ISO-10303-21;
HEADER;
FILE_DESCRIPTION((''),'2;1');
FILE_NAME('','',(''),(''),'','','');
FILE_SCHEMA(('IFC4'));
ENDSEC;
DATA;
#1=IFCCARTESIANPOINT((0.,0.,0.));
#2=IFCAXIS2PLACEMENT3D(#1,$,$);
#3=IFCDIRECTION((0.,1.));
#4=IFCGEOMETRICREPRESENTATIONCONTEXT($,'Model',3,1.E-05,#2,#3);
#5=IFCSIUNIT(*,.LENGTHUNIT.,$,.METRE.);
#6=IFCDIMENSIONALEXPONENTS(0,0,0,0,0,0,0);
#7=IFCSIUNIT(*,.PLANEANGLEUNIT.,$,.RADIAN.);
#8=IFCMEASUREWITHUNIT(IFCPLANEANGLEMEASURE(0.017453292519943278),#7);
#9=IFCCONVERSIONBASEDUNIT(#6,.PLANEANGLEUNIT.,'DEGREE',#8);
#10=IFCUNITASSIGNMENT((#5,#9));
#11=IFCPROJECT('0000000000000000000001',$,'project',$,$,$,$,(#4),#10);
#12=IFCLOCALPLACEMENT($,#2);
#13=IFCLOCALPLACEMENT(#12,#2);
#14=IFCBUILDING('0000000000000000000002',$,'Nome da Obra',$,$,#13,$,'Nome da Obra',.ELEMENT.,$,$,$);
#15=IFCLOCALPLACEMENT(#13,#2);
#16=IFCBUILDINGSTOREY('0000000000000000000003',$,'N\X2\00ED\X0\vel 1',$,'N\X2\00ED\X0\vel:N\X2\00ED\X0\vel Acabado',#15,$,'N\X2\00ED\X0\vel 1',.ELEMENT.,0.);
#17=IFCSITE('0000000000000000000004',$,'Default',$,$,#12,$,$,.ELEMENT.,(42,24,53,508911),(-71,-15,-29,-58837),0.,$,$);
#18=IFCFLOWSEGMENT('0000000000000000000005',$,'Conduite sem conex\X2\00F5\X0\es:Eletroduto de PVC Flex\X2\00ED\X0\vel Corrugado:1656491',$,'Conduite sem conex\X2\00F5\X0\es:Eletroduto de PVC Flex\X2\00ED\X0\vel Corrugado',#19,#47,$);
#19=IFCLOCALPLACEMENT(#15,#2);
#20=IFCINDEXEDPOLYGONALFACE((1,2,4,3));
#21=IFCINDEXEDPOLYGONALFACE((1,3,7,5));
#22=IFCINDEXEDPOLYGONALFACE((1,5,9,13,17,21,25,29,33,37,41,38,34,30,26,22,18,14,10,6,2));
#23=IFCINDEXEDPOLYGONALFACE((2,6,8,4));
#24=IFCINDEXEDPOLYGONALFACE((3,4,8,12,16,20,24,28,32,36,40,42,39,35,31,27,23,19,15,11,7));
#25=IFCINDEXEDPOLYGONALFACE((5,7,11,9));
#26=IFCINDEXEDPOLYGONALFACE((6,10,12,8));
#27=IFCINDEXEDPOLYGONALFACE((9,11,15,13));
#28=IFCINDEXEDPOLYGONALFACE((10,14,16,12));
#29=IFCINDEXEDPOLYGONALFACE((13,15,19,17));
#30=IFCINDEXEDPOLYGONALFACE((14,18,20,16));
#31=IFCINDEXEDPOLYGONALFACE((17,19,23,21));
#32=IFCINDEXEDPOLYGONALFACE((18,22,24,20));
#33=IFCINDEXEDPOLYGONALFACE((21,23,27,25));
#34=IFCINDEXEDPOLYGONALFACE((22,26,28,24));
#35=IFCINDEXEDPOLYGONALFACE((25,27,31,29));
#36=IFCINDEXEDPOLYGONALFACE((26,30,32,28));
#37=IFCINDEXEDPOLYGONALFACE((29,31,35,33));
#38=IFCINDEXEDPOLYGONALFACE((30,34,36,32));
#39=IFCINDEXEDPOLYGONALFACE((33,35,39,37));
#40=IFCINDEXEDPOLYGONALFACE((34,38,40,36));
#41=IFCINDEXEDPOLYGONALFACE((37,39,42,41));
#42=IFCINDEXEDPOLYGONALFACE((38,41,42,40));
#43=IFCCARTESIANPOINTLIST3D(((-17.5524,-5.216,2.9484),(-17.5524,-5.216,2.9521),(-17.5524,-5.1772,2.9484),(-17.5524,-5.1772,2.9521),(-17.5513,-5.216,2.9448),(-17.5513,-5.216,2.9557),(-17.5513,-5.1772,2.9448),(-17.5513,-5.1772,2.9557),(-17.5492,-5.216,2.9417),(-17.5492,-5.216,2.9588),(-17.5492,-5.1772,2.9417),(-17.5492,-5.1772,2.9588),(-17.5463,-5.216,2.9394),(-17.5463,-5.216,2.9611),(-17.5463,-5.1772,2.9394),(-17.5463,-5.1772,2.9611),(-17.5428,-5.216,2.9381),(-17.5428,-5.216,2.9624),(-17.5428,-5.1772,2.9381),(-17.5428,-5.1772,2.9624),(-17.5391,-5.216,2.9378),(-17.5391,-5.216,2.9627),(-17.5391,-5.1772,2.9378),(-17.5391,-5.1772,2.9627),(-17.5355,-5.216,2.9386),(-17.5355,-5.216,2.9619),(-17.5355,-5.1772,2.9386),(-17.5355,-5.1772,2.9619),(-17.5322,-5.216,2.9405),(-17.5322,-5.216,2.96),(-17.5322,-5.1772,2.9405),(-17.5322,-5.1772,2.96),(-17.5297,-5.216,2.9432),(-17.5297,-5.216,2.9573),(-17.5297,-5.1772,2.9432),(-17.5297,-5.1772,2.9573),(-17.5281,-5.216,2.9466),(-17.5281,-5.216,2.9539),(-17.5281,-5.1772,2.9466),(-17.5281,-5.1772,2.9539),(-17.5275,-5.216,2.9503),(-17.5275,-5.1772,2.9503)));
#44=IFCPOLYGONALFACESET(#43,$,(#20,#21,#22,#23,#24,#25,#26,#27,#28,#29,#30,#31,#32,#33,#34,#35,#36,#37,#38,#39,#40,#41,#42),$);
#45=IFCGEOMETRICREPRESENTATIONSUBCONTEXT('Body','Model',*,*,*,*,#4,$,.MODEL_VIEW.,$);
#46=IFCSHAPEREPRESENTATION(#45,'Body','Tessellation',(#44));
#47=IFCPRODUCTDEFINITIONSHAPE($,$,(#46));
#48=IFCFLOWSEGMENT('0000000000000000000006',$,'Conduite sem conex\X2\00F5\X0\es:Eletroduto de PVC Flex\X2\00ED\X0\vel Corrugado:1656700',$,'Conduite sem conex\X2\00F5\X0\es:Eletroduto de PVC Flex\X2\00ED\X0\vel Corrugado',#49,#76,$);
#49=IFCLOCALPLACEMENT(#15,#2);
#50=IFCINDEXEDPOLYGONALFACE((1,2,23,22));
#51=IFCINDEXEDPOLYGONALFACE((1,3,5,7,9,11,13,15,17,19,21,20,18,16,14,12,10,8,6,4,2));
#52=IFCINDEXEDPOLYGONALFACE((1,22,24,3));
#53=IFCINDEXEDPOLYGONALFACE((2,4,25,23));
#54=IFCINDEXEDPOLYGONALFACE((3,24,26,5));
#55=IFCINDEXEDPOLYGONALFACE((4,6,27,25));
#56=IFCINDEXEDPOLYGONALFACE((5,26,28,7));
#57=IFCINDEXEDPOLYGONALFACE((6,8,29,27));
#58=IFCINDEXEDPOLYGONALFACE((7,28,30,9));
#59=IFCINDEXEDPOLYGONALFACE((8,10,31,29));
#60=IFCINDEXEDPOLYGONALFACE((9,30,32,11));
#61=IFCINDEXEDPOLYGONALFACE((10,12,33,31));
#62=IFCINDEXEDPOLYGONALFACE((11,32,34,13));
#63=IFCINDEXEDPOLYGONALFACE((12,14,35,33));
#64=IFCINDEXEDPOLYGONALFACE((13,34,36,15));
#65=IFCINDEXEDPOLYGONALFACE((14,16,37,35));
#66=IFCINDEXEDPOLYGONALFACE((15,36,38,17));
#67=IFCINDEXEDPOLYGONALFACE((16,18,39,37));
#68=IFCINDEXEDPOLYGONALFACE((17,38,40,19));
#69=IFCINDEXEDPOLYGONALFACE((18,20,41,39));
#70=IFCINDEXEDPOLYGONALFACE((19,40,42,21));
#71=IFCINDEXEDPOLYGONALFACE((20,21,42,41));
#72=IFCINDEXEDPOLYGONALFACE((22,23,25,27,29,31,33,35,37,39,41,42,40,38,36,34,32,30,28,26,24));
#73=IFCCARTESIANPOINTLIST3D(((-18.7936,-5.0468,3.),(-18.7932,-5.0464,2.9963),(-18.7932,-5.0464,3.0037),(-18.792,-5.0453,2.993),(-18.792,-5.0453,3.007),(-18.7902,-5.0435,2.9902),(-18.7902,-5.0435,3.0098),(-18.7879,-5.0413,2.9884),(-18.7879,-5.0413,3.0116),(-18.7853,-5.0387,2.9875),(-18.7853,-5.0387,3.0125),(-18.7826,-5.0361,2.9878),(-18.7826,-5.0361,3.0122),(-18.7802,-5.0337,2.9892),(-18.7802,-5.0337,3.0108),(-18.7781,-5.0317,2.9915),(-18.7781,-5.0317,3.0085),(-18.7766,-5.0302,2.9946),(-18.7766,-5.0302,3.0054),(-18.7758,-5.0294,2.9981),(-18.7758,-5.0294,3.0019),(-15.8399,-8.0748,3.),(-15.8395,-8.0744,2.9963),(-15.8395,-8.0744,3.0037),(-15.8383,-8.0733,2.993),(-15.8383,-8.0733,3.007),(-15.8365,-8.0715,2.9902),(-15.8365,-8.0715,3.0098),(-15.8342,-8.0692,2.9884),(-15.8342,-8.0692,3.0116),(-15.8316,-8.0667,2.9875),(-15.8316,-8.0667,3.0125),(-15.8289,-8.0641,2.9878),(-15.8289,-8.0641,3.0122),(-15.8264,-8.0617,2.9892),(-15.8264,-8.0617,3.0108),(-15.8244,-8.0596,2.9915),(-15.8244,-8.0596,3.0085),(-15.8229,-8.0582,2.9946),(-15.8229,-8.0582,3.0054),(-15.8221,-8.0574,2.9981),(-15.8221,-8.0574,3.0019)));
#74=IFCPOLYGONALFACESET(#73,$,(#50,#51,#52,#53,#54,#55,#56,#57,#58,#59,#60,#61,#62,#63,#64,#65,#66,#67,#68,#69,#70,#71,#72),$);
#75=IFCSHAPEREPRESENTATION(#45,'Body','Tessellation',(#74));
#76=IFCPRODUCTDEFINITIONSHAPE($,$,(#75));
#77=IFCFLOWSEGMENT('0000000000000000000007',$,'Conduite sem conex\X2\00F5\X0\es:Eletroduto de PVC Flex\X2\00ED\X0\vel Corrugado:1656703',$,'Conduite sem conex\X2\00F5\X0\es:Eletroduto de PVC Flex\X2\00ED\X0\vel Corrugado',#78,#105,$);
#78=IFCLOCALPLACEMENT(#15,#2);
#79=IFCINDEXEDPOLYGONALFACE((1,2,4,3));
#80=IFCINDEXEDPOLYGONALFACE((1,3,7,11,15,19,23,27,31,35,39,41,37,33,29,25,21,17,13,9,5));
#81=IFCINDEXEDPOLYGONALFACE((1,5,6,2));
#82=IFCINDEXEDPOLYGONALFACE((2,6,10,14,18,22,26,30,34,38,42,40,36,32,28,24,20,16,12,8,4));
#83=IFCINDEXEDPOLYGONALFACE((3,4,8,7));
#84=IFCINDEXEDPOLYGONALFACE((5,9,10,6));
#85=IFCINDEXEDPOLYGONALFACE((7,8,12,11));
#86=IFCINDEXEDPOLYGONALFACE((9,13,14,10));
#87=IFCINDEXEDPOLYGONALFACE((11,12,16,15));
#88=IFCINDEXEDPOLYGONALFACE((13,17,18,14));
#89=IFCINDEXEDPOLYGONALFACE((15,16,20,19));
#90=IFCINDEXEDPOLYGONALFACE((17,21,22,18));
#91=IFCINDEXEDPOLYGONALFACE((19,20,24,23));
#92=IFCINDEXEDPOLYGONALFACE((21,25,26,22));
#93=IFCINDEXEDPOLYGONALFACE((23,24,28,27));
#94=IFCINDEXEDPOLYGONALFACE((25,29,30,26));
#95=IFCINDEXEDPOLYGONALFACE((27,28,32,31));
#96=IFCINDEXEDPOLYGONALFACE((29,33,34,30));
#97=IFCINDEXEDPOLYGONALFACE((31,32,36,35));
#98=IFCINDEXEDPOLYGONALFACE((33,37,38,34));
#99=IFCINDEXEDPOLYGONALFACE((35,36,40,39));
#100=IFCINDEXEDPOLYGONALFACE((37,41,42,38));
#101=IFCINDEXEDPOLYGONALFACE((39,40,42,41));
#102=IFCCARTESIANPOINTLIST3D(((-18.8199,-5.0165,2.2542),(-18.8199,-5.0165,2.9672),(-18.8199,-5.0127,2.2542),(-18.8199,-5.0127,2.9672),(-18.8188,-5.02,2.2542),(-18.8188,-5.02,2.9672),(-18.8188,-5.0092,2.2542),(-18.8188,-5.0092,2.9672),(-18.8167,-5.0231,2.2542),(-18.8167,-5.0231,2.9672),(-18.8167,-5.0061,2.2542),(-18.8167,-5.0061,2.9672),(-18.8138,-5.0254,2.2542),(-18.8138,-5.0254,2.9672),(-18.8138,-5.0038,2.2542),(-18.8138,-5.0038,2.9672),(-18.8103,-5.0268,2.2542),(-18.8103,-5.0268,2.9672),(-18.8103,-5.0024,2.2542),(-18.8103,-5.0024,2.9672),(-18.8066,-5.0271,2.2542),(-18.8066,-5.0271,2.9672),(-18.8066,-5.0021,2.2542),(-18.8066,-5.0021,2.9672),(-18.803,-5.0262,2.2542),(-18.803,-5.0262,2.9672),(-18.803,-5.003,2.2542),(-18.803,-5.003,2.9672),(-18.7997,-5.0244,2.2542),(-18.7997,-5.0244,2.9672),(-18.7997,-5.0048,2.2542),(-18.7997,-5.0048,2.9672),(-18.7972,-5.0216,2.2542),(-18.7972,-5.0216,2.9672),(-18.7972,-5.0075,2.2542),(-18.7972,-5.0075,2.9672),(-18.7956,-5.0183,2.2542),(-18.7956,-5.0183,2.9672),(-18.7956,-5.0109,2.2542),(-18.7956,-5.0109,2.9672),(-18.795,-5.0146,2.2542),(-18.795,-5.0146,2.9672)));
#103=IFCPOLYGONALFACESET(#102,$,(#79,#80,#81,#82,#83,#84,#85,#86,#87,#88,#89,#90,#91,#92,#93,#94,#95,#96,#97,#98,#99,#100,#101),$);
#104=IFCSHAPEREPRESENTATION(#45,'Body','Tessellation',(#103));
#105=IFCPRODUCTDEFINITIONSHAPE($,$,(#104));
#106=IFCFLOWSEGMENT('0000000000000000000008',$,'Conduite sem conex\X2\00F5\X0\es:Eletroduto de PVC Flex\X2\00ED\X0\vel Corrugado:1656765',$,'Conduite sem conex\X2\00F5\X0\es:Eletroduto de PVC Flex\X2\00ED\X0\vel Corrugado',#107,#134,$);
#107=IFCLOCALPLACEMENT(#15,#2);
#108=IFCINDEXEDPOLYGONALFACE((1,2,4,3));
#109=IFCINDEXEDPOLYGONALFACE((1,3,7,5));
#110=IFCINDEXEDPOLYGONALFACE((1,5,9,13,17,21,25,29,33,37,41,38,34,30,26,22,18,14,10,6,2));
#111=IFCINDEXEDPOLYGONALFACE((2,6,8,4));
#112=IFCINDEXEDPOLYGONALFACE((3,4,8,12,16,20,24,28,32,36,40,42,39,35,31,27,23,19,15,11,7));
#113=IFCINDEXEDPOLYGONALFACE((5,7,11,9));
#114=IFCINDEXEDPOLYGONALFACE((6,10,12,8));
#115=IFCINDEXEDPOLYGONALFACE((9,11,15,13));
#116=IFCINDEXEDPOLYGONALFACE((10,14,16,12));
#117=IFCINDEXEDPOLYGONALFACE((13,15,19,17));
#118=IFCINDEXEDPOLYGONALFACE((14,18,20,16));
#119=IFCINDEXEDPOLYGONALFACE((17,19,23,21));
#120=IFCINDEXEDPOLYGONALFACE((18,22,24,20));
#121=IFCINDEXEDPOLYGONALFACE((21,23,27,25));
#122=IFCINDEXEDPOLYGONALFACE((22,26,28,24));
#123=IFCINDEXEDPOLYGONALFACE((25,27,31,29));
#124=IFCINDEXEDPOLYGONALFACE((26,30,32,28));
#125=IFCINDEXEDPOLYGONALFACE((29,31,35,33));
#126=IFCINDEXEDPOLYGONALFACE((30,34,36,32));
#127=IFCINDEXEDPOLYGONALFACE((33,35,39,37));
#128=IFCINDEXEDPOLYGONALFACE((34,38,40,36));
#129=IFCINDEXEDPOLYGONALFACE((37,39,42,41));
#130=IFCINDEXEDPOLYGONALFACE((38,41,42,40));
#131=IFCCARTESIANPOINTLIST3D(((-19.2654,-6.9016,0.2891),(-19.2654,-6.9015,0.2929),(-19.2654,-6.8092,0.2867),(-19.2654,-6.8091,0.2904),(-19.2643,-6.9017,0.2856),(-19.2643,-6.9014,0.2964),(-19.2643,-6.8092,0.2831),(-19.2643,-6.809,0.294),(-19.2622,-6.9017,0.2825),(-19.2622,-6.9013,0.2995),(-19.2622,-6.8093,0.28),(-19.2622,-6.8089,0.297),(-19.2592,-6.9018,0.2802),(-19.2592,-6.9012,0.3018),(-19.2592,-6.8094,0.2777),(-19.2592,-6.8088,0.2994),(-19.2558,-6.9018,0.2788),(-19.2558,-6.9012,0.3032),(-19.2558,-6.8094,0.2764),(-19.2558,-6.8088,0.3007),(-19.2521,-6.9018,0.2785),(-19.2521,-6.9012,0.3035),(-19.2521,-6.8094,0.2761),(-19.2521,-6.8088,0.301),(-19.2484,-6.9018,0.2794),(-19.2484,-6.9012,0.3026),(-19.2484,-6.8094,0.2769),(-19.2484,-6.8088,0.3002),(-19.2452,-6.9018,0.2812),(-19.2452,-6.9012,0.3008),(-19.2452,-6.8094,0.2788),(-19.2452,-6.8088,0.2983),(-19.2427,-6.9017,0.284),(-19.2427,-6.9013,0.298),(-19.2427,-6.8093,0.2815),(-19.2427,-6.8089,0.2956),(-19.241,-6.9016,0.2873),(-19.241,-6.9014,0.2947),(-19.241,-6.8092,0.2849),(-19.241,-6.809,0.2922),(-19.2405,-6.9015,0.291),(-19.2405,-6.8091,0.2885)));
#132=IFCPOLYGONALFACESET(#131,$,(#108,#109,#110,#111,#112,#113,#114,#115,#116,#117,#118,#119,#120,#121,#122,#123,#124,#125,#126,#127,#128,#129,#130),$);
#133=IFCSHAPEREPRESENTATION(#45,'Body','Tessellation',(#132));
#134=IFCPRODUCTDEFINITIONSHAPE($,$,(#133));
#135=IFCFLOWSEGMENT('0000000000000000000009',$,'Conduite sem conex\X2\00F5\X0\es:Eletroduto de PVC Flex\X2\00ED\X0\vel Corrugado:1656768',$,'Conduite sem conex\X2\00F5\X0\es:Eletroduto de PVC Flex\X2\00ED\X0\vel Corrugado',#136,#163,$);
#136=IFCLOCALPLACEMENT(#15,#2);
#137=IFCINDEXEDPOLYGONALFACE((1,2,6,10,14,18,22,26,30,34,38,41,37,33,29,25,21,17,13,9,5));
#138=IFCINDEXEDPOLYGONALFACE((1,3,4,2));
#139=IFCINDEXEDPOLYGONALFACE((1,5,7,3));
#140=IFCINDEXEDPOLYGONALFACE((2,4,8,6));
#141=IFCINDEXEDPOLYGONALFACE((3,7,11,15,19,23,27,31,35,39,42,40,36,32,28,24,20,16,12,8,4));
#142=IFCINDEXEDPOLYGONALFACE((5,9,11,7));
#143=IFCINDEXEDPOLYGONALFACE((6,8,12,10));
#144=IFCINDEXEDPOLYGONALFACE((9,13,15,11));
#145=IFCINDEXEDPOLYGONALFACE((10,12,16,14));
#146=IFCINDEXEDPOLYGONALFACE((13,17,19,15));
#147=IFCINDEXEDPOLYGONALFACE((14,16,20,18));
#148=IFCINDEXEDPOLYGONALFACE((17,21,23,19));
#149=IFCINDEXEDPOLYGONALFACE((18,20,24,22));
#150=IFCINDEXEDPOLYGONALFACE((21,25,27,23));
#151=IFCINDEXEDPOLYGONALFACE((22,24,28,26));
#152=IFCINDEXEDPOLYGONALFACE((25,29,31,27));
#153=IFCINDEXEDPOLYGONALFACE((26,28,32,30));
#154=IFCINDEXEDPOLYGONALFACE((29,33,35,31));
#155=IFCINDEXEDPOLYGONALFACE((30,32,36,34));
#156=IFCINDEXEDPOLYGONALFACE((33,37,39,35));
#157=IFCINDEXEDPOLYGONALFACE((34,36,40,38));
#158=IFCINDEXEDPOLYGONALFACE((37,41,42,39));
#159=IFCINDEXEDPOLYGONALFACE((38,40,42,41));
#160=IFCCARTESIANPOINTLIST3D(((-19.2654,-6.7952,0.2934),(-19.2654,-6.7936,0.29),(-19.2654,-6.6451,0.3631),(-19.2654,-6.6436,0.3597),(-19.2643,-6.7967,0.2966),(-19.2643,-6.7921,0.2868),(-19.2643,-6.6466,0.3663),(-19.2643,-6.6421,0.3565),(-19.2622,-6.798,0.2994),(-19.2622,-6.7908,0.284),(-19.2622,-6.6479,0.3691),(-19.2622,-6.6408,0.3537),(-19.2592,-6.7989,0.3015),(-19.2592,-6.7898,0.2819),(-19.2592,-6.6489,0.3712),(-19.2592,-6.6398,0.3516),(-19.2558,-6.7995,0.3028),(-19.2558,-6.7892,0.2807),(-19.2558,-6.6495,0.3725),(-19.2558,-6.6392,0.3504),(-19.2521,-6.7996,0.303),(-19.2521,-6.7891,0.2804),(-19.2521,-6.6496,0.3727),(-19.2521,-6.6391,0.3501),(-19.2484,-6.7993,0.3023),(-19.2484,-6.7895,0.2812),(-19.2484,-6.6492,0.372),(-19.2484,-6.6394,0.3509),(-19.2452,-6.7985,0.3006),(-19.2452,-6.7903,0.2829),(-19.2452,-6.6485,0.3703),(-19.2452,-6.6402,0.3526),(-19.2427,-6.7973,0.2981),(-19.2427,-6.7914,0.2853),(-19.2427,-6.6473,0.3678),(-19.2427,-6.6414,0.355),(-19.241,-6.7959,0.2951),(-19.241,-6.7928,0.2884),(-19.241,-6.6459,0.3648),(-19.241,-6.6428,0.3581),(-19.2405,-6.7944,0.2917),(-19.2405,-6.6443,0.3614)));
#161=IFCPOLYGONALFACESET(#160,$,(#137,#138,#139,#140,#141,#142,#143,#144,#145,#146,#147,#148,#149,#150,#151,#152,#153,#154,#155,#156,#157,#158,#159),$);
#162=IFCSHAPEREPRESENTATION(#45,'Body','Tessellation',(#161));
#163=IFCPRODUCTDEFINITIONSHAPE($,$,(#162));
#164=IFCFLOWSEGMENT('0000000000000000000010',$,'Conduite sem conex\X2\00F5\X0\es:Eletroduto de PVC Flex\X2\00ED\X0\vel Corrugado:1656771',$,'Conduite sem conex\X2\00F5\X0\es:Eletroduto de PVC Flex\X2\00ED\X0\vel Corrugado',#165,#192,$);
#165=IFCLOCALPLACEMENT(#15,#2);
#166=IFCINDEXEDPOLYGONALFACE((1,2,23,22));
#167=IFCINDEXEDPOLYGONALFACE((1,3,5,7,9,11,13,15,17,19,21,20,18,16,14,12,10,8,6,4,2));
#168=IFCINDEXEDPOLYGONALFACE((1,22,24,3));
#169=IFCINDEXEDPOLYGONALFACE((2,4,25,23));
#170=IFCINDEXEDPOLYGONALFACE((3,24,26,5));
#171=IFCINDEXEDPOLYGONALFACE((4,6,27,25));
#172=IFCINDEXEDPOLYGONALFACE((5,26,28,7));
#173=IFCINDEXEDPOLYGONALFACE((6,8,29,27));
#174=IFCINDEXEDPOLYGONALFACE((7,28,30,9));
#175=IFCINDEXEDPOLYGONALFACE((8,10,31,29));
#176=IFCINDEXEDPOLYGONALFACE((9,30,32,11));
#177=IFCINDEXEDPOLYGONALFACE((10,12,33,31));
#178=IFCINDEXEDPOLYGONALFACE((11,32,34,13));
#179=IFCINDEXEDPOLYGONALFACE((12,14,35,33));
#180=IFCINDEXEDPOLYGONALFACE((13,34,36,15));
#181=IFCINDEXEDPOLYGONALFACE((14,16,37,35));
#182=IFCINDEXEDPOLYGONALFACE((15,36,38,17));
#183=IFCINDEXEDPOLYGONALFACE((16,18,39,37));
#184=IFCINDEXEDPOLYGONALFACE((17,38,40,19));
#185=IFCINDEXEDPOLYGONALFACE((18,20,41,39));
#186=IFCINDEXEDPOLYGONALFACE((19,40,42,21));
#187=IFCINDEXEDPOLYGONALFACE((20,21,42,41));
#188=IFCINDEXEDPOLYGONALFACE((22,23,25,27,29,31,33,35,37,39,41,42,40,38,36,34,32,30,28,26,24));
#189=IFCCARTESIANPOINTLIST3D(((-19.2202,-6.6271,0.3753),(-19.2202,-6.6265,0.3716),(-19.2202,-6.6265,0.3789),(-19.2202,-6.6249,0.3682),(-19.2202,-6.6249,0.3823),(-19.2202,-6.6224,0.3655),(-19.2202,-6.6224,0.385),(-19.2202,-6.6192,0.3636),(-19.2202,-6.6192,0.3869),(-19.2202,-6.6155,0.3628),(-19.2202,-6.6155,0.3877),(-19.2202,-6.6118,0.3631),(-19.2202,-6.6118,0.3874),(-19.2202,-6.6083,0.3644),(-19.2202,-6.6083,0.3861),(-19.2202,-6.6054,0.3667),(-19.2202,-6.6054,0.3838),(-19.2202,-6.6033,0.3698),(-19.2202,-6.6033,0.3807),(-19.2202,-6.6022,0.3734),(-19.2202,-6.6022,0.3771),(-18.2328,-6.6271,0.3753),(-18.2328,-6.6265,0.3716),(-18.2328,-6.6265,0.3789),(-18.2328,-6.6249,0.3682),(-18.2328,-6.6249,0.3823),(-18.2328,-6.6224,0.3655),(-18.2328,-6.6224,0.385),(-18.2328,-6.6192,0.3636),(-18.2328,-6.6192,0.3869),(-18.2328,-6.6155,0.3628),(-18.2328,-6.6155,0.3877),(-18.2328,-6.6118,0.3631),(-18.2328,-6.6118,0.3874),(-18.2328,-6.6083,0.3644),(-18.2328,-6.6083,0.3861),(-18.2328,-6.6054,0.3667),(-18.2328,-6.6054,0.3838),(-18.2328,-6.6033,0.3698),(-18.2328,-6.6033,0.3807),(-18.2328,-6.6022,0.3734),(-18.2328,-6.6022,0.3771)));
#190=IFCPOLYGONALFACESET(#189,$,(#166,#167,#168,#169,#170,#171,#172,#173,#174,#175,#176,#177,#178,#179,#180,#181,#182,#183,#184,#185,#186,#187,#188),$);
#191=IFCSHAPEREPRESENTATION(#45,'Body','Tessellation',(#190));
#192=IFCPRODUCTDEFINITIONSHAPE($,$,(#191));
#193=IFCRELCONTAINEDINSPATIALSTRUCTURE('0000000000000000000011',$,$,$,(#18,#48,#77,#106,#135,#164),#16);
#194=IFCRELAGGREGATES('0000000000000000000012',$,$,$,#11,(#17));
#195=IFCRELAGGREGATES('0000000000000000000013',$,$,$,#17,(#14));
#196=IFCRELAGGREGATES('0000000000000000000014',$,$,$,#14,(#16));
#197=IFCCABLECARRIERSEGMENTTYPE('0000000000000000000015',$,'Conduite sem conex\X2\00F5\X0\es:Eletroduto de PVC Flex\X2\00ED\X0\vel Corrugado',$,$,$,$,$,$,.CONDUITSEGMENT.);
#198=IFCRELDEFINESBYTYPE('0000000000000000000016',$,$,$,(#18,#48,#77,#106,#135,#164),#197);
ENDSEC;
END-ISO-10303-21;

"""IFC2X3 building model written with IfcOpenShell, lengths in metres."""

from ifc_helpers import new_model, entity, si_unit, converted_unit, direction, frame, frame_2d, origin, origin_2d_with_axis, place, context, subcontext, project, spatial, circle, extrude, type_object, element, save


model = new_model("IFC2X3")

# Units and contexts
model_context = context("Model", 3, precision=1e-05, world=origin(), true_north=direction((0.0, 1.0)))
body_context = subcontext(model_context, "Body", "Model", "MODEL_VIEW")
ifc_project = project(units=[si_unit("LENGTHUNIT", "METRE"), converted_unit("PLANEANGLEUNIT", "DEGREE", entity("IfcPlaneAngleMeasure", 0.017453292519943278), si_unit("PLANEANGLEUNIT", "RADIAN"), dimensions=[0, 0, 0, 0, 0, 0, 0])], contexts=[model_context])

# Site, building, storey
site_placement = place(None, origin())
site = spatial("IfcSite", under=ifc_project, at=site_placement, Name="Default", CompositionType="ELEMENT", RefLatitude=(42, 24, 53, 508911), RefLongitude=(-71, -15, -29, -58837), RefElevation=0.0)
building_placement = place(site_placement, origin())
building = spatial("IfcBuilding", under=site, at=building_placement, Name="Nome da Obra", LongName="Nome da Obra", CompositionType="ELEMENT")
storey_placement = place(building_placement, origin())
storey = spatial("IfcBuildingStorey", under=building, at=storey_placement, Name="Nível 1", ObjectType="Nível:Nível Acabado", LongName="Nível 1", CompositionType="ELEMENT", Elevation=0.0)

# Flow segments
cable_carrier_segment_type = type_object("IfcCableCarrierSegmentType", Name="Conduite sem conexões:Eletroduto de PVC Flexível Corrugado", PredefinedType="CONDUITSEGMENT")
flow_segment_1_placement = place(storey_placement, origin())
element("IfcFlowSegment", 1, at=flow_segment_1_placement, inside=storey, type_object=cable_carrier_segment_type, Name="Conduite sem conexões:Eletroduto de PVC Flexível Corrugado:1656491", ObjectType="Conduite sem conexões:Eletroduto de PVC Flexível Corrugado", context=body_context, shape_type="SweptSolid", body=[
    extrude(circle(Radius=0.0125, at=frame_2d((0.0, 0.0), x_axis=(1.0, 0.0))), frame((-17.54, -5.216, 2.9503), z_axis=(0.0, 1.0, 0.0), x_axis=(1.0, 0.0, 0.0)), (0.0, 0.0, 1.0), 0.0388),
])
flow_segment_2_placement = place(storey_placement, origin())
element("IfcFlowSegment", 2, at=flow_segment_2_placement, inside=storey, type_object=cable_carrier_segment_type, Name="Conduite sem conexões:Eletroduto de PVC Flexível Corrugado:1656700", ObjectType="Conduite sem conexões:Eletroduto de PVC Flexível Corrugado", context=body_context, shape_type="SweptSolid", body=[
    extrude(circle(Radius=0.0125, at=frame_2d((0.0, 0.0), x_axis=(1.0, 0.0))), frame((-18.7846, -5.0381, 3.0), z_axis=(0.698276, -0.715829, 0.0), x_axis=(-0.715829, -0.698276, 0.0)), (0.0, 0.0, 1.0), 4.23),
])
flow_segment_3_placement = place(storey_placement, origin())
element("IfcFlowSegment", 3, at=flow_segment_3_placement, inside=storey, type_object=cable_carrier_segment_type, Name="Conduite sem conexões:Eletroduto de PVC Flexível Corrugado:1656703", ObjectType="Conduite sem conexões:Eletroduto de PVC Flexível Corrugado", context=body_context, shape_type="SweptSolid", body=[
    extrude(circle(Radius=0.0125, at=origin_2d_with_axis()), frame((-18.8075, -5.0146, 2.2542)), (0.0, 0.0, 1.0), 0.713),
])
flow_segment_4_placement = place(storey_placement, origin())
element("IfcFlowSegment", 4, at=flow_segment_4_placement, inside=storey, type_object=cable_carrier_segment_type, Name="Conduite sem conexões:Eletroduto de PVC Flexível Corrugado:1656765", ObjectType="Conduite sem conexões:Eletroduto de PVC Flexível Corrugado", context=body_context, shape_type="SweptSolid", body=[
    extrude(circle(Radius=0.0125, at=frame_2d((0.0, 0.0), x_axis=(1.0, 0.0))), frame((-19.253, -6.9015, 0.291), z_axis=(0.000002, 0.999645, -0.026658), x_axis=(1.0, -0.000002, 0.0)), (0.0, 0.0, 1.0), 0.0924),
])
flow_segment_5_placement = place(storey_placement, origin())
element("IfcFlowSegment", 5, at=flow_segment_5_placement, inside=storey, type_object=cable_carrier_segment_type, Name="Conduite sem conexões:Eletroduto de PVC Flexível Corrugado:1656768", ObjectType="Conduite sem conexões:Eletroduto de PVC Flexível Corrugado", context=body_context, shape_type="SweptSolid", body=[
    extrude(circle(Radius=0.0125, at=frame_2d((0.0, 0.0), x_axis=(1.0, 0.0))), frame((-19.253, -6.7944, 0.2917), z_axis=(0.000003, 0.906898, 0.42135), x_axis=(1.0, -0.000004, 0.0)), (0.0, 0.0, 1.0), 0.1654),
])
flow_segment_6_placement = place(storey_placement, origin())
element("IfcFlowSegment", 6, at=flow_segment_6_placement, inside=storey, type_object=cable_carrier_segment_type, Name="Conduite sem conexões:Eletroduto de PVC Flexível Corrugado:1656771", ObjectType="Conduite sem conexões:Eletroduto de PVC Flexível Corrugado", context=body_context, shape_type="SweptSolid", body=[
    extrude(circle(Radius=0.0125, at=origin_2d_with_axis()), frame((-19.2202, -6.6146, 0.3753), z_axis=(1.0, -0.000002, 0.0), x_axis=(-0.000002, -1.0, 0.0)), (0.0, 0.0, 1.0), 0.9874),
])

save(model, "model.ifc")
